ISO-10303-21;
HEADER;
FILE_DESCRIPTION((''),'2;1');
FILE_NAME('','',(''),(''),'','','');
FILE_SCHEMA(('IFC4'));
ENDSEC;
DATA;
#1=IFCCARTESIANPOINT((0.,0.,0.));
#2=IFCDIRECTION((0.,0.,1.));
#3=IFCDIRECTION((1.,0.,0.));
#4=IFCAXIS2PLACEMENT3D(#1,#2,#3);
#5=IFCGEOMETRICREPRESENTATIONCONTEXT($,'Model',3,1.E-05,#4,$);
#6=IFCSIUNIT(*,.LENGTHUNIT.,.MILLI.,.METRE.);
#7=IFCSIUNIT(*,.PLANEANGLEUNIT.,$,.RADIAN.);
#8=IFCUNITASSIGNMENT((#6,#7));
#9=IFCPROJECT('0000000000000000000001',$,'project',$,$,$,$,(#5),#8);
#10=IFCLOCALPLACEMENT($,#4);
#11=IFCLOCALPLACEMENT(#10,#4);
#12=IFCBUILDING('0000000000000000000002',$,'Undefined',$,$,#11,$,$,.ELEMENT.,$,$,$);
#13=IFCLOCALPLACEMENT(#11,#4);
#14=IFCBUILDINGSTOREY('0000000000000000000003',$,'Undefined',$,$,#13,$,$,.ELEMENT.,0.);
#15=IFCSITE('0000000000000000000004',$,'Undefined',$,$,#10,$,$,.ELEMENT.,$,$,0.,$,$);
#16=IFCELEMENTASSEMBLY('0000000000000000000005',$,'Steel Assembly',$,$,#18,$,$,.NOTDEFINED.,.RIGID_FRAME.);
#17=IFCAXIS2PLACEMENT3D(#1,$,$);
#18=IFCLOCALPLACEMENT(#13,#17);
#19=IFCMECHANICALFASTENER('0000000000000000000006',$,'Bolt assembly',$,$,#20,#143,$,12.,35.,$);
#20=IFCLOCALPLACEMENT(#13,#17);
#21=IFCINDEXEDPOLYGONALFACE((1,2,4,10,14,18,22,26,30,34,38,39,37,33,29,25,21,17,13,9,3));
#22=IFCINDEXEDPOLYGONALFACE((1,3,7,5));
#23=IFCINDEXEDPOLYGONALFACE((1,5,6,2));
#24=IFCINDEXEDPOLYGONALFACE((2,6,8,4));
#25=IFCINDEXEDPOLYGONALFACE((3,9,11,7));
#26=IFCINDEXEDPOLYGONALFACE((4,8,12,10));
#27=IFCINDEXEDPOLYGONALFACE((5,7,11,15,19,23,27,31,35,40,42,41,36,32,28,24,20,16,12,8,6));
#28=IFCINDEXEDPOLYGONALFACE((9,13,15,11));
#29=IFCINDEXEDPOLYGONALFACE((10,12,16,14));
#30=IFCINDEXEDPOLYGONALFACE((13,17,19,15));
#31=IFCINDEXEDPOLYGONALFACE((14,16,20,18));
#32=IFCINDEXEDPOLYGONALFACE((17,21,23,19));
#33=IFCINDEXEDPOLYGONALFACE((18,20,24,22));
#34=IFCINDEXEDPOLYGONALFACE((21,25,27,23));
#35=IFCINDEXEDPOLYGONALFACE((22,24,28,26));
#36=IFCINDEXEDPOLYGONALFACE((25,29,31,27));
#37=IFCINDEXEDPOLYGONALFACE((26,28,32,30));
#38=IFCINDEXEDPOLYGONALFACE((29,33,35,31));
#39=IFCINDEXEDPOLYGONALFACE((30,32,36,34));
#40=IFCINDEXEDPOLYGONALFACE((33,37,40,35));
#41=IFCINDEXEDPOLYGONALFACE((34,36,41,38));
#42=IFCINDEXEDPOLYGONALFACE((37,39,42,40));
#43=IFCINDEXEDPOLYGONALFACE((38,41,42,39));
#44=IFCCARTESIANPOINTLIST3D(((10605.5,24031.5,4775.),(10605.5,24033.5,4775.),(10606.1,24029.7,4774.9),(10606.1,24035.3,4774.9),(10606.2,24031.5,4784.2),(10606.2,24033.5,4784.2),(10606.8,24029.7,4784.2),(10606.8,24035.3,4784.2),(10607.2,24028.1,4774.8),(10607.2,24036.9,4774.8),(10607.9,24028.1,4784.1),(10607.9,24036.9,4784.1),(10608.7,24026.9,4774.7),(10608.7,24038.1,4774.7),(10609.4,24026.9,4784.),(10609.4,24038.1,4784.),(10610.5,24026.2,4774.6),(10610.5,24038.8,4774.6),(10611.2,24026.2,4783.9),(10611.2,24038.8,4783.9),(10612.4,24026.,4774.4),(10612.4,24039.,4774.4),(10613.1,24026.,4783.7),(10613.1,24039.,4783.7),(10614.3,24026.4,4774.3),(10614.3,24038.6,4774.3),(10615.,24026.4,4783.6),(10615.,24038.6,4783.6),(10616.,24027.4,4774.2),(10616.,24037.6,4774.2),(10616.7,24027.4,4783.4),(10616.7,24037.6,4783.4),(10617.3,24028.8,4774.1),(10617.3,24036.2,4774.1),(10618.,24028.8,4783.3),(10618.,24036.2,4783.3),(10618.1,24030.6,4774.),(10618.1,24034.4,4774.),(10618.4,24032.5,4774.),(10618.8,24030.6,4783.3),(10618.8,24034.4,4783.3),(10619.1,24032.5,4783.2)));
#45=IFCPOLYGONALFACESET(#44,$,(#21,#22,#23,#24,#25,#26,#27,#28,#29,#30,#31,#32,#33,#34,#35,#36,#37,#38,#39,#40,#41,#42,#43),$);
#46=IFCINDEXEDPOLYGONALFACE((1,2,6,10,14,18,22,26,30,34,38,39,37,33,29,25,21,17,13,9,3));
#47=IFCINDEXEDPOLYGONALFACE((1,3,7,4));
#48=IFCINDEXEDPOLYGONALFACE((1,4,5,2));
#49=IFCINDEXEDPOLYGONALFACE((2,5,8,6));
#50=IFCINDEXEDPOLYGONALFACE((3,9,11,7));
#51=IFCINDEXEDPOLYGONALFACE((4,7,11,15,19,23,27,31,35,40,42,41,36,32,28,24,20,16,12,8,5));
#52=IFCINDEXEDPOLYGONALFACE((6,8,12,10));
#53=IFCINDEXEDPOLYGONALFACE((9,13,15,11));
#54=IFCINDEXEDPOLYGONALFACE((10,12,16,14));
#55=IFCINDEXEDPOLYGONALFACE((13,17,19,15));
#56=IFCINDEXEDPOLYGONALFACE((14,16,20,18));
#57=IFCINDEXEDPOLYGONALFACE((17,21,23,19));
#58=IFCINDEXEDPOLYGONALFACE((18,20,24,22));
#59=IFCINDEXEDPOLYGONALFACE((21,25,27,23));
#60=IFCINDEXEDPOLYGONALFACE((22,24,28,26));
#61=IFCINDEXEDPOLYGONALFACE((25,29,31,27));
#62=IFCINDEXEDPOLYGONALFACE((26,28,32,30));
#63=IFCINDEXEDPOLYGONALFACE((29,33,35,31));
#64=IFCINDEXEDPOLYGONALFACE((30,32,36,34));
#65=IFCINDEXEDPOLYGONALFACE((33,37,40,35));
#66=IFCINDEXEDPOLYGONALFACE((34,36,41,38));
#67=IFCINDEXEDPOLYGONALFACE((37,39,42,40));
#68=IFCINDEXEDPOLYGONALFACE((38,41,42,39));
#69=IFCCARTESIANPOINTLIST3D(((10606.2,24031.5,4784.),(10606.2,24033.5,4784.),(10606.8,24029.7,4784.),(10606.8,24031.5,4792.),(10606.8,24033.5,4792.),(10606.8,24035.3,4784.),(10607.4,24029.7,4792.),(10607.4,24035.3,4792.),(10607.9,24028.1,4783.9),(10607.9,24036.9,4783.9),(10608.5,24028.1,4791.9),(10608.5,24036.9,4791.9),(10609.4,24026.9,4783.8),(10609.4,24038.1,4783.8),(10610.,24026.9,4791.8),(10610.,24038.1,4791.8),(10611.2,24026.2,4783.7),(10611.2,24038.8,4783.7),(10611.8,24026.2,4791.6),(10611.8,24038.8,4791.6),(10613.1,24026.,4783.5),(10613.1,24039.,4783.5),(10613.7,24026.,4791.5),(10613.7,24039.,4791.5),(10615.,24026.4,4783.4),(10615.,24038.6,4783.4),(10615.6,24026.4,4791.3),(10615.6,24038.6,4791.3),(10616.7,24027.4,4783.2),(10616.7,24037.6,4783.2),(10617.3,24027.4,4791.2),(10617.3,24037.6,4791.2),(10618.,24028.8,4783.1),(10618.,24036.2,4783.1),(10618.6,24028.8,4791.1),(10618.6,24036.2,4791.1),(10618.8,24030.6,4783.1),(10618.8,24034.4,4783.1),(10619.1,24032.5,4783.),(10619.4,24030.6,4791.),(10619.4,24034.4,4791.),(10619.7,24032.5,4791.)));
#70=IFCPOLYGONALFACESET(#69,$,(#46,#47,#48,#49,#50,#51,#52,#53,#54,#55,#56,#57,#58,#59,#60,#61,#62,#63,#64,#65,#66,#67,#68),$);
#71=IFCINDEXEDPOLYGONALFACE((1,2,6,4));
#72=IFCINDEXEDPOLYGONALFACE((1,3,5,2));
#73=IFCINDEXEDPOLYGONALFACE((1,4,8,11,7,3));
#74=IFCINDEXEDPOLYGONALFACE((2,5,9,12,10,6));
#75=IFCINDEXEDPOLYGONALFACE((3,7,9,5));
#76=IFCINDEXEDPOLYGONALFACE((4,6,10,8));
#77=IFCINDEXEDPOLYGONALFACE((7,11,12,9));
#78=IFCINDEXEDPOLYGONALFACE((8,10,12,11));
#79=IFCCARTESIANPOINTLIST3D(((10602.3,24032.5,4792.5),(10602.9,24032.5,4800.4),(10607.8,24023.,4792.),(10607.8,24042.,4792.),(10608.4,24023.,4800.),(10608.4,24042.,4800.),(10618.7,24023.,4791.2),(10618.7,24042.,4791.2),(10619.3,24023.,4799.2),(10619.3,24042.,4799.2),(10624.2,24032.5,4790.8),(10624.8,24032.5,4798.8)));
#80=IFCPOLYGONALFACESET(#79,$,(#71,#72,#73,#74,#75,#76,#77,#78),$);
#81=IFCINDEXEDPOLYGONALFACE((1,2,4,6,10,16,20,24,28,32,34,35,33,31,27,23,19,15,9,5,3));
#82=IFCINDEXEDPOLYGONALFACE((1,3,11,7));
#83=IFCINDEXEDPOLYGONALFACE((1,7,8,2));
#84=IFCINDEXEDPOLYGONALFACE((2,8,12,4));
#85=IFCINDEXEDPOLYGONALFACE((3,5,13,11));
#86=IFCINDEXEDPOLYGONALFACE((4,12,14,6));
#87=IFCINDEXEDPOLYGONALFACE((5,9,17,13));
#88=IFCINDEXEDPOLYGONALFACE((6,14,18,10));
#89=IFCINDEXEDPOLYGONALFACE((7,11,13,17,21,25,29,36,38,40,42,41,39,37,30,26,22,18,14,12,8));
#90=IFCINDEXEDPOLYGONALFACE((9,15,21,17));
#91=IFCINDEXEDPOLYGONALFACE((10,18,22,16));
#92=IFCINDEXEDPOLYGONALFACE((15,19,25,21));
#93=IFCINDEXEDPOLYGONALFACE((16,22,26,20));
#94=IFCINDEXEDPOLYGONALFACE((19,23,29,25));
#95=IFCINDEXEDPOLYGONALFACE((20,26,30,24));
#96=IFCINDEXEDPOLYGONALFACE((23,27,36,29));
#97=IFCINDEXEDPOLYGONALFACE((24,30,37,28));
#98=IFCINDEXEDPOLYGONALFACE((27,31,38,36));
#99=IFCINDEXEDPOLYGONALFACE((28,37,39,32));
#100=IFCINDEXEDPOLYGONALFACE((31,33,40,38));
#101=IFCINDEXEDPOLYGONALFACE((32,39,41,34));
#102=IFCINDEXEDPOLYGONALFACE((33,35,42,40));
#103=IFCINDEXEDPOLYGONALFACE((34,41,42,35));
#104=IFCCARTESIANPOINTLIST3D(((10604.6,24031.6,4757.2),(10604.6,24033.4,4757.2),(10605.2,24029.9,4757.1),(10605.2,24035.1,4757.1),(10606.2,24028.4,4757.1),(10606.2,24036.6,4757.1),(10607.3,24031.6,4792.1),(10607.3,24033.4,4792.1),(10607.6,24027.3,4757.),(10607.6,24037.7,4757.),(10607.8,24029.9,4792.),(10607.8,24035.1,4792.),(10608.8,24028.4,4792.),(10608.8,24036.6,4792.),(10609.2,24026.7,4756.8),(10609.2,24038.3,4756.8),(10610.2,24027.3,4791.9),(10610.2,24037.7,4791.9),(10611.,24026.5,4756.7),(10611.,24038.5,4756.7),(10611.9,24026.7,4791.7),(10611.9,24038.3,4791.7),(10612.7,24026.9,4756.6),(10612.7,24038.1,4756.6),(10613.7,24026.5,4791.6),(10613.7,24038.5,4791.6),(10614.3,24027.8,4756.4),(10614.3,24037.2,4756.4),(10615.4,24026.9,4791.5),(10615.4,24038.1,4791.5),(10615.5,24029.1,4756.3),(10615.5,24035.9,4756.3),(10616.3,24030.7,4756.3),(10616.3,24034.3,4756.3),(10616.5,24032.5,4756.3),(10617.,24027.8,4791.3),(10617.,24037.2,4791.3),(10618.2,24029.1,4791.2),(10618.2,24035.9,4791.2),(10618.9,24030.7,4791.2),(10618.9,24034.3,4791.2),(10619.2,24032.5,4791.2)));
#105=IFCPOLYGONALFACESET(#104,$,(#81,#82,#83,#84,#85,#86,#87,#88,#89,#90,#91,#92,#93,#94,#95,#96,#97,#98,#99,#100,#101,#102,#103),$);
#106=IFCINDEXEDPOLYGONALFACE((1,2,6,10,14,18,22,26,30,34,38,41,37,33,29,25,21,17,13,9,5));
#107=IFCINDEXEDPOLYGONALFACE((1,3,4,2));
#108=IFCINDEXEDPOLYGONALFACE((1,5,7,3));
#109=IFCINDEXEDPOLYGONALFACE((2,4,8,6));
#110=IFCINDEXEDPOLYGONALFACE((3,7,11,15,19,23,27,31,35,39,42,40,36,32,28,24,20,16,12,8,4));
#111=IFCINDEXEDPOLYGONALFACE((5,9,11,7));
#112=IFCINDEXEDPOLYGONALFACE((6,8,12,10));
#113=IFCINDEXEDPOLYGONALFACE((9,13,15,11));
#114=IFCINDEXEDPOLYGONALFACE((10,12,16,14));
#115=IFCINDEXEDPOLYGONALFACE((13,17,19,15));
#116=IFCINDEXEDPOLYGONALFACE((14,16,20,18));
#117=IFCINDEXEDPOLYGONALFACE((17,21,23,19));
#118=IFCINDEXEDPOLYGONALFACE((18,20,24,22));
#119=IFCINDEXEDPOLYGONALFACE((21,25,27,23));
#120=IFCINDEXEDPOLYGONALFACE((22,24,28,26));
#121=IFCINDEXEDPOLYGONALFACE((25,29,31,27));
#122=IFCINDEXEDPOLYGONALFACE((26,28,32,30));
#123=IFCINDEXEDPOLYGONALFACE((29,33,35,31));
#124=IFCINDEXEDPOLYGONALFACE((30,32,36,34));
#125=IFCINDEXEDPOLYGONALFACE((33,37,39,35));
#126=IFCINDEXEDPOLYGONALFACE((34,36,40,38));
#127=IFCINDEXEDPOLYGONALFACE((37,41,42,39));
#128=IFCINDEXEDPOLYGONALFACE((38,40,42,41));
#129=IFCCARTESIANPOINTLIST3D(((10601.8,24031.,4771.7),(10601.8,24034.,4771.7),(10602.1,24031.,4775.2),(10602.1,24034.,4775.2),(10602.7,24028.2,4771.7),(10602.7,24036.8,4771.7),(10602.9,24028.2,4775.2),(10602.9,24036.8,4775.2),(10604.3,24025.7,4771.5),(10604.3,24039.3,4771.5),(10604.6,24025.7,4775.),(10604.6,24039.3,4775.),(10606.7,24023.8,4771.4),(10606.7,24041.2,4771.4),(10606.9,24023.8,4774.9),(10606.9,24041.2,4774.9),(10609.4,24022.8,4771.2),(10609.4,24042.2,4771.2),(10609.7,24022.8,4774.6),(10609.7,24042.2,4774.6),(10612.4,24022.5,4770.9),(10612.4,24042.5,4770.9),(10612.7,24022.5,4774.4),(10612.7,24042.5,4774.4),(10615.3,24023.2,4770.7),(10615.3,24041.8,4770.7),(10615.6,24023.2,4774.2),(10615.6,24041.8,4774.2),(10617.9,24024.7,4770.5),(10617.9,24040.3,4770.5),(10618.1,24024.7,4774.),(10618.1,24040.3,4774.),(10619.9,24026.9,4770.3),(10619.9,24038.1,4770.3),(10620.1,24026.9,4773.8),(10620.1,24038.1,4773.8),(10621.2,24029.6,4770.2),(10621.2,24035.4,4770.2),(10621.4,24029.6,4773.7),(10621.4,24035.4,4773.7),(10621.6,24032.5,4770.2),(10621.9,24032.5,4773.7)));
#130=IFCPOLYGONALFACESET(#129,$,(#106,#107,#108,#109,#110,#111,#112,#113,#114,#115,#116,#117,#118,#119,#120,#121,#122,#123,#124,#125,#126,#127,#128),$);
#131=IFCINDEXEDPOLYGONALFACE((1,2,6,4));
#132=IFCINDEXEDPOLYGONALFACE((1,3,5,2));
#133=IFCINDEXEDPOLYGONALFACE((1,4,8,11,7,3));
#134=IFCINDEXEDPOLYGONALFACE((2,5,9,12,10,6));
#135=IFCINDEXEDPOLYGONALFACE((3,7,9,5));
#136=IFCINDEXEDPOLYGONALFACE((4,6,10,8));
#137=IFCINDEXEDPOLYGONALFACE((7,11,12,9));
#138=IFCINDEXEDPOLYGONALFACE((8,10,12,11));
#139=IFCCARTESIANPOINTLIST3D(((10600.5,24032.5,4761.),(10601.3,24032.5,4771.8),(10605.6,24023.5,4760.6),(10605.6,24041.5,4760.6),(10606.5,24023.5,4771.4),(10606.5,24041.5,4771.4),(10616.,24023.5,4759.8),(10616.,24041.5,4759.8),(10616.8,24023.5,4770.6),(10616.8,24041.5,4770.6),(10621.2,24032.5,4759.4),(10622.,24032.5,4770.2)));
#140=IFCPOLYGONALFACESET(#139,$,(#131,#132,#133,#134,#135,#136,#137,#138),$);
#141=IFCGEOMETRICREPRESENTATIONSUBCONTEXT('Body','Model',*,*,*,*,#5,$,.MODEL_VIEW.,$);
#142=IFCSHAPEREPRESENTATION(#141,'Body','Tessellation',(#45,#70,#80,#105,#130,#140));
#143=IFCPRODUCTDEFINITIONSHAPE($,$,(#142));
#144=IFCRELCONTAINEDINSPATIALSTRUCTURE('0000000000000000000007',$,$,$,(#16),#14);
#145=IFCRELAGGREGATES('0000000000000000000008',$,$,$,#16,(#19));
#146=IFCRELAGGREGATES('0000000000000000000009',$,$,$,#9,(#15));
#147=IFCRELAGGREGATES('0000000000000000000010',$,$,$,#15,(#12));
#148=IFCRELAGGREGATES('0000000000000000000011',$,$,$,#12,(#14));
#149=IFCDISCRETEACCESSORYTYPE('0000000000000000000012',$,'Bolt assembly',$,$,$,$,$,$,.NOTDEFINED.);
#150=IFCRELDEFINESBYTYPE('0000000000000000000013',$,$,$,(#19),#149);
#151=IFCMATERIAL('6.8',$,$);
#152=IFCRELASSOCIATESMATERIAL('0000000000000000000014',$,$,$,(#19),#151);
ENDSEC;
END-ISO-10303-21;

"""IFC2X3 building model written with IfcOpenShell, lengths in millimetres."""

from ifc_helpers import new_model, si_unit, frame, origin_with_axes, origin_2d_with_axis, place, context, subcontext, project, spatial, polyline, circle, outline, extrude, source, transform, mapped, material, type_object, element, aggregate, save


model = new_model("IFC2X3")

# Units and contexts
model_context = context("Model", 3, precision=1e-05, world=origin_with_axes())
body_context = subcontext(model_context, "Body", "Model", "MODEL_VIEW")
ifc_project = project(units=[si_unit("LENGTHUNIT", "METRE", prefix="MILLI"), si_unit("PLANEANGLEUNIT", "RADIAN")], contexts=[model_context])

# Site, building, storey
site_placement = place(None, origin_with_axes())
site = spatial("IfcSite", under=ifc_project, at=site_placement, Name="Undefined", CompositionType="ELEMENT", RefElevation=0.0)
building_placement = place(site_placement, origin_with_axes())
building = spatial("IfcBuilding", under=site, at=building_placement, Name="Undefined", CompositionType="ELEMENT")
storey_placement = place(building_placement, origin_with_axes())
storey = spatial("IfcBuildingStorey", under=building, at=storey_placement, Name="Undefined", CompositionType="ELEMENT", Elevation=0.0)

# Shared definitions
ifc_material_1 = material(Name="6.8")
discrete_accessory_type_1 = type_object("IfcDiscreteAccessoryType", Name="Bolt assembly")

# Element assembly, mechanical fastener
shared_shape_1 = source(origin_with_axes(), body_context, "Body", "SweptSolid", [
    extrude(circle(Radius=6.5, at=origin_2d_with_axis()), frame((0.0, -0.1, 0.0), z_axis=(0.0, 1.0, 0.0), x_axis=(1.0, 0.0, 0.0)), (0.0, 0.0, 1.0), 9.3),
    extrude(circle(Radius=6.5, at=origin_2d_with_axis()), frame((0.0, -7.9, 0.0), z_axis=(0.0, 1.0, 0.0), x_axis=(1.0, 0.0, 0.0)), (0.0, 0.0, 1.0), 8.0),
    extrude(outline(polyline([(11.0, 0.0), (5.5, 9.5), (-5.5, 9.5), (-11.0, 0.0), (-5.5, -9.5), (5.5, -9.5), (11.0, 0.0)])), frame((0.0, -16.0, 0.0), z_axis=(0.0, 1.0, 0.0), x_axis=(1.0, 0.0, 0.0)), (0.0, 0.0, 1.0), 8.0),
    extrude(circle(Radius=6.0, at=origin_2d_with_axis()), frame((0.0, -8.0, 0.0), z_axis=(0.0, 1.0, 0.0), x_axis=(1.0, 0.0, 0.0)), (0.0, 0.0, 1.0), 35.0),
    extrude(circle(Radius=10.0, at=origin_2d_with_axis()), frame((0.0, 9.2, 0.0), z_axis=(0.0, 1.0, 0.0), x_axis=(1.0, 0.0, 0.0)), (0.0, 0.0, 1.0), 3.5),
    extrude(outline(polyline([(10.4, 0.0), (5.2, 9.0), (-5.2, 9.0), (-10.4, 0.0), (-5.2, -9.0), (5.2, -9.0), (10.4, 0.0)])), frame((0.0, 12.7, 0.0), z_axis=(0.0, 1.0, 0.0), x_axis=(1.0, 0.0, 0.0)), (0.0, 0.0, 1.0), 10.8),
])
assembly_1_placement = place(storey_placement, origin_with_axes())
assembly_1 = element("IfcElementAssembly", 1, at=assembly_1_placement, inside=storey, Name="Steel Assembly", AssemblyPlace="NOTDEFINED", PredefinedType="RIGID_FRAME")
mechanical_fastener_1_placement = place(assembly_1_placement, frame((10612.6, 24032.5, 4783.6), z_axis=(0.0, 1.0, 0.0), x_axis=(0.997054, 0.0, -0.076696)))
mechanical_fastener_1 = element("IfcMechanicalFastener", 2, at=mechanical_fastener_1_placement, type_object=discrete_accessory_type_1, material=ifc_material_1, Name="Bolt assembly", NominalDiameter=12.0, NominalLength=35.0, context=body_context, shape_type="MappedRepresentation", body=[
    mapped(shared_shape_1, transform((0.0, 0.0, 0.0))),
])
aggregate(assembly_1, [mechanical_fastener_1])

save(model, "model.ifc")
